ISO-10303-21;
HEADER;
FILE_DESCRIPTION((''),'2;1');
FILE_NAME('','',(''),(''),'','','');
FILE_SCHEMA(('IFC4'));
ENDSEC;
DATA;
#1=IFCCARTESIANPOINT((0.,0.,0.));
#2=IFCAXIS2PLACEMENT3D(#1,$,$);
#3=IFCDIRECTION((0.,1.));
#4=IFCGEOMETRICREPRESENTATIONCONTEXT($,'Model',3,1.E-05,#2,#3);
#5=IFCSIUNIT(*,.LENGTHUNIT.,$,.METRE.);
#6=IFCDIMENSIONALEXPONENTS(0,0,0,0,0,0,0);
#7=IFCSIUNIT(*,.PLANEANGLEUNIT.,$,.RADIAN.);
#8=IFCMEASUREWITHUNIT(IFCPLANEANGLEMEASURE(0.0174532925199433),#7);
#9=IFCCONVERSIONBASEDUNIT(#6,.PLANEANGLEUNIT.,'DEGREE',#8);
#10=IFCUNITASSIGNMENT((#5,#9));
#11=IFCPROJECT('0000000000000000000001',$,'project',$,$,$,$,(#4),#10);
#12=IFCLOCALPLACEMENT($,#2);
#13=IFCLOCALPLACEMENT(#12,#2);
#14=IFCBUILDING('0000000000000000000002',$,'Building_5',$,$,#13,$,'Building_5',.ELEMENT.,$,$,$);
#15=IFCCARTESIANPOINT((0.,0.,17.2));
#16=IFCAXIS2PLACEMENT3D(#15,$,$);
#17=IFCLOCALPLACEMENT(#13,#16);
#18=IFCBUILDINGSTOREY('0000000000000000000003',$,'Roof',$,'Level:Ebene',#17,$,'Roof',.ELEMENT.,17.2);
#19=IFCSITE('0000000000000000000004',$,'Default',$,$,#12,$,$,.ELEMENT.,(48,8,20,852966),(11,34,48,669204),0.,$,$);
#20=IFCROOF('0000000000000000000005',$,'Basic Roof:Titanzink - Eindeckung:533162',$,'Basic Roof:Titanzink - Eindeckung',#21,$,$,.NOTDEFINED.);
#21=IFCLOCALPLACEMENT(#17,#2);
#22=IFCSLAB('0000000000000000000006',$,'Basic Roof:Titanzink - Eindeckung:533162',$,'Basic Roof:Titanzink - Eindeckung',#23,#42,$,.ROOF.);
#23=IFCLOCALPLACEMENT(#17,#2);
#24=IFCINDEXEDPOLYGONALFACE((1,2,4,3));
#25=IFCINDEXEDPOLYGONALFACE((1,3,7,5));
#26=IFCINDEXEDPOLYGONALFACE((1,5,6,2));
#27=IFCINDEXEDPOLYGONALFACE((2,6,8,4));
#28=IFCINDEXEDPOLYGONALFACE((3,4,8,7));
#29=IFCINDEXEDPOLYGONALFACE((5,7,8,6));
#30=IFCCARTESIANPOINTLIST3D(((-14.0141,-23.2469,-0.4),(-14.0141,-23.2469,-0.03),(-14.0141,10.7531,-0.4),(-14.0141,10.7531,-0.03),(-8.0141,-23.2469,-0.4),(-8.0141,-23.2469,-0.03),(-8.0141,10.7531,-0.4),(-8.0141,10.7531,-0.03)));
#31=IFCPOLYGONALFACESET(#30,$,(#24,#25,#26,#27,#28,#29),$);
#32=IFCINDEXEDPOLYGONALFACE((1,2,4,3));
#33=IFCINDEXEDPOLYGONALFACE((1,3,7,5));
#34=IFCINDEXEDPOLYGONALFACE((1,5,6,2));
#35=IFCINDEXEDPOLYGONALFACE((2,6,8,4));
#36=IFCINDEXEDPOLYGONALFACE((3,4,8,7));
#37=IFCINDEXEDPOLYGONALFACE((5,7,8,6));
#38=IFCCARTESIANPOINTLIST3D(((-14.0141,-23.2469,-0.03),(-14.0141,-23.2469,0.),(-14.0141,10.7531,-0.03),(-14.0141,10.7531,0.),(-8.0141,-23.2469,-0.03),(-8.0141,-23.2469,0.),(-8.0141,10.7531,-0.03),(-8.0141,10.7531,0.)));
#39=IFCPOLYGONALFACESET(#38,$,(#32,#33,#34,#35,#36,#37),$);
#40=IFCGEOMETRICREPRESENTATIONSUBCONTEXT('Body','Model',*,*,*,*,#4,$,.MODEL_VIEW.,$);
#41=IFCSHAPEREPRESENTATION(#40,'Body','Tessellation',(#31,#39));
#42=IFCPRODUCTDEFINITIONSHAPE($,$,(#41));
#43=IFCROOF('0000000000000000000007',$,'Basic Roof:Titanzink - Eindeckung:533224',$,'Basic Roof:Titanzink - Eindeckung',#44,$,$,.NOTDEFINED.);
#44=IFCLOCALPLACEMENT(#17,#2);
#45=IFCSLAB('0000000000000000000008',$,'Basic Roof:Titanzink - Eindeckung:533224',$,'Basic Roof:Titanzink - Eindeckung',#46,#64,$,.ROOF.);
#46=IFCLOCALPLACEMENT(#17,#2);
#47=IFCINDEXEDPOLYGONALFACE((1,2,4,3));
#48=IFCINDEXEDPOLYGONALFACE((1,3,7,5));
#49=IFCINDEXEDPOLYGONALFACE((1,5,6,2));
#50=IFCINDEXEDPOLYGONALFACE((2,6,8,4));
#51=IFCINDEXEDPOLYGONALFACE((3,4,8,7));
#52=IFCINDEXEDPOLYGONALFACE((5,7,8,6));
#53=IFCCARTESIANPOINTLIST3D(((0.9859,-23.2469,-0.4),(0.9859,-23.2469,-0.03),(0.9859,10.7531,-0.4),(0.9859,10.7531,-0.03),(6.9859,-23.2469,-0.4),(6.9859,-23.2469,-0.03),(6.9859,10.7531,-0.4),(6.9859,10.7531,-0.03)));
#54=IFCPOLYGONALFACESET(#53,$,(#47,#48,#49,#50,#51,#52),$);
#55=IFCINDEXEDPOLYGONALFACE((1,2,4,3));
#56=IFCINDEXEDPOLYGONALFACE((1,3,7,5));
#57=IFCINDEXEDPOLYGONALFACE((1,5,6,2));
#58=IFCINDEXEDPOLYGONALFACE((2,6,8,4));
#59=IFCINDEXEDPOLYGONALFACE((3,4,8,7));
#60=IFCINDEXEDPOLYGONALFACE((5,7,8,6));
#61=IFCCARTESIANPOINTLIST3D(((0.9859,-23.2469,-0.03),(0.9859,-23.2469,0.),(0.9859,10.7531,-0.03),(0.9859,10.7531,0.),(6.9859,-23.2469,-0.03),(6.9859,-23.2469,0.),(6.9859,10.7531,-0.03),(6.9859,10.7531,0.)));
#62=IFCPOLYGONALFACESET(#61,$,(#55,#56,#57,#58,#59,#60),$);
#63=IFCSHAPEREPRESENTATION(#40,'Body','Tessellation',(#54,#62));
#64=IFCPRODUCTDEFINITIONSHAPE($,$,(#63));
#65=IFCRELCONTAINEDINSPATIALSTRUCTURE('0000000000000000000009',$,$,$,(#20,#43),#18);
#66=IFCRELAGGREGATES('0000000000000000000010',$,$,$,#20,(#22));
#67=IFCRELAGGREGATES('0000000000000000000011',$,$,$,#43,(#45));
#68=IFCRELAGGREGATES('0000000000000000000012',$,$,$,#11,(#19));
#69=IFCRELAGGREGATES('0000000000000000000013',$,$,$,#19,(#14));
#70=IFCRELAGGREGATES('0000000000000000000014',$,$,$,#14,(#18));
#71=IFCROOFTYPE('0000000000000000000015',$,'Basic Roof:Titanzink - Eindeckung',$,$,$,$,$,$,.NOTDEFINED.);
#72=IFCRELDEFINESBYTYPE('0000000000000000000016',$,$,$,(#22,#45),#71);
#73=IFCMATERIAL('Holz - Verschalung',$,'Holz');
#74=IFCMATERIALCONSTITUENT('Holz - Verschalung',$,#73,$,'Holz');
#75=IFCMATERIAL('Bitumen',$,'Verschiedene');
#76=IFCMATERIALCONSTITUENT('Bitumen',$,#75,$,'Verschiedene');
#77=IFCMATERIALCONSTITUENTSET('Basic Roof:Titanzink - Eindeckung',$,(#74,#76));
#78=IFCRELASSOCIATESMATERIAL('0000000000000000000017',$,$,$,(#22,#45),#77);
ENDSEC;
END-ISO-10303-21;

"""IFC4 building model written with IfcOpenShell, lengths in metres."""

from ifc_helpers import new_model, entity, si_unit, converted_unit, direction, frame, origin, place, context, subcontext, project, spatial, indexed_curve, outline, extrude, material, constituent, constituent_set, type_object, element, aggregate, save


model = new_model("IFC4")

# Units and contexts
model_context = context("Model", 3, precision=1e-05, world=origin(), true_north=direction((0.0, 1.0)))
body_context = subcontext(model_context, "Body", "Model", "MODEL_VIEW")
ifc_project = project(units=[si_unit("LENGTHUNIT", "METRE"), converted_unit("PLANEANGLEUNIT", "DEGREE", entity("IfcPlaneAngleMeasure", 0.0174532925199433), si_unit("PLANEANGLEUNIT", "RADIAN"), dimensions=[0, 0, 0, 0, 0, 0, 0])], contexts=[model_context])

# Site, building, storey
site_placement = place(None, origin())
site = spatial("IfcSite", under=ifc_project, at=site_placement, Name="Default", CompositionType="ELEMENT", RefLatitude=(48, 8, 20, 852966), RefLongitude=(11, 34, 48, 669204), RefElevation=0.0)
building_placement = place(site_placement, origin())
building = spatial("IfcBuilding", under=site, at=building_placement, Name="Building_5", LongName="Building_5", CompositionType="ELEMENT")
storey_placement = place(building_placement, frame((0.0, 0.0, 17.2)))
storey = spatial("IfcBuildingStorey", under=building, at=storey_placement, Name="Roof", ObjectType="Level:Ebene", LongName="Roof", CompositionType="ELEMENT", Elevation=17.2)

# Roofs, slabs
roof_1_placement = place(storey_placement, frame((-14.0141, -23.2469, -0.4)))
roof_1 = element("IfcRoof", 1, at=roof_1_placement, inside=storey, Name="Basic Roof:Titanzink - Eindeckung:533162", ObjectType="Basic Roof:Titanzink - Eindeckung", PredefinedType="NOTDEFINED")
ifc_material_1 = material(Name="Holz - Verschalung", Category="Holz")
ifc_constituent_1 = constituent(ifc_material_1, Name="Holz - Verschalung", Category="Holz")
ifc_material_2 = material(Name="Bitumen", Category="Verschiedene")
ifc_constituent_2 = constituent(ifc_material_2, Name="Bitumen", Category="Verschiedene")
ifc_constituent_set = constituent_set(constituents=[ifc_constituent_1, ifc_constituent_2], Name="Basic Roof:Titanzink - Eindeckung")
roof_type = type_object("IfcRoofType", Name="Basic Roof:Titanzink - Eindeckung", PredefinedType="NOTDEFINED")
slab_1_placement = place(roof_1_placement, origin())
slab_1 = element("IfcSlab", 2, at=slab_1_placement, type_object=roof_type, material=ifc_constituent_set, Name="Basic Roof:Titanzink - Eindeckung:533162", ObjectType="Basic Roof:Titanzink - Eindeckung", PredefinedType="ROOF", context=body_context, shape_type="SweptSolid", body=[
    extrude(outline(indexed_curve([(-3.0, 17.0), (-3.0, -17.0), (3.0, -17.0), (3.0, 17.0), (-3.0, 17.0)], self_intersect=False)), frame((3.0, 17.0, 0.0)), (0.0, 0.0, 1.0), 0.37),
    extrude(outline(indexed_curve([(-3.0, 17.0), (-3.0, -17.0), (3.0, -17.0), (3.0, 17.0), (-3.0, 17.0)], self_intersect=False)), frame((3.0, 17.0, 0.37)), (0.0, 0.0, 1.0), 0.03),
])
aggregate(roof_1, [slab_1])
roof_2_placement = place(storey_placement, frame((0.9859, -23.2469, -0.4)))
roof_2 = element("IfcRoof", 3, at=roof_2_placement, inside=storey, Name="Basic Roof:Titanzink - Eindeckung:533224", ObjectType="Basic Roof:Titanzink - Eindeckung", PredefinedType="NOTDEFINED")
slab_2_placement = place(roof_2_placement, origin())
slab_2 = element("IfcSlab", 4, at=slab_2_placement, type_object=roof_type, material=ifc_constituent_set, Name="Basic Roof:Titanzink - Eindeckung:533224", ObjectType="Basic Roof:Titanzink - Eindeckung", PredefinedType="ROOF", context=body_context, shape_type="SweptSolid", body=[
    extrude(outline(indexed_curve([(-3.0, 17.0), (-3.0, -17.0), (3.0, -17.0), (3.0, 17.0), (-3.0, 17.0)], self_intersect=False)), frame((3.0, 17.0, 0.0)), (0.0, 0.0, 1.0), 0.37),
    extrude(outline(indexed_curve([(-3.0, 17.0), (-3.0, -17.0), (3.0, -17.0), (3.0, 17.0), (-3.0, 17.0)], self_intersect=False)), frame((3.0, 17.0, 0.37)), (0.0, 0.0, 1.0), 0.03),
])
aggregate(roof_2, [slab_2])

save(model, "model.ifc")
